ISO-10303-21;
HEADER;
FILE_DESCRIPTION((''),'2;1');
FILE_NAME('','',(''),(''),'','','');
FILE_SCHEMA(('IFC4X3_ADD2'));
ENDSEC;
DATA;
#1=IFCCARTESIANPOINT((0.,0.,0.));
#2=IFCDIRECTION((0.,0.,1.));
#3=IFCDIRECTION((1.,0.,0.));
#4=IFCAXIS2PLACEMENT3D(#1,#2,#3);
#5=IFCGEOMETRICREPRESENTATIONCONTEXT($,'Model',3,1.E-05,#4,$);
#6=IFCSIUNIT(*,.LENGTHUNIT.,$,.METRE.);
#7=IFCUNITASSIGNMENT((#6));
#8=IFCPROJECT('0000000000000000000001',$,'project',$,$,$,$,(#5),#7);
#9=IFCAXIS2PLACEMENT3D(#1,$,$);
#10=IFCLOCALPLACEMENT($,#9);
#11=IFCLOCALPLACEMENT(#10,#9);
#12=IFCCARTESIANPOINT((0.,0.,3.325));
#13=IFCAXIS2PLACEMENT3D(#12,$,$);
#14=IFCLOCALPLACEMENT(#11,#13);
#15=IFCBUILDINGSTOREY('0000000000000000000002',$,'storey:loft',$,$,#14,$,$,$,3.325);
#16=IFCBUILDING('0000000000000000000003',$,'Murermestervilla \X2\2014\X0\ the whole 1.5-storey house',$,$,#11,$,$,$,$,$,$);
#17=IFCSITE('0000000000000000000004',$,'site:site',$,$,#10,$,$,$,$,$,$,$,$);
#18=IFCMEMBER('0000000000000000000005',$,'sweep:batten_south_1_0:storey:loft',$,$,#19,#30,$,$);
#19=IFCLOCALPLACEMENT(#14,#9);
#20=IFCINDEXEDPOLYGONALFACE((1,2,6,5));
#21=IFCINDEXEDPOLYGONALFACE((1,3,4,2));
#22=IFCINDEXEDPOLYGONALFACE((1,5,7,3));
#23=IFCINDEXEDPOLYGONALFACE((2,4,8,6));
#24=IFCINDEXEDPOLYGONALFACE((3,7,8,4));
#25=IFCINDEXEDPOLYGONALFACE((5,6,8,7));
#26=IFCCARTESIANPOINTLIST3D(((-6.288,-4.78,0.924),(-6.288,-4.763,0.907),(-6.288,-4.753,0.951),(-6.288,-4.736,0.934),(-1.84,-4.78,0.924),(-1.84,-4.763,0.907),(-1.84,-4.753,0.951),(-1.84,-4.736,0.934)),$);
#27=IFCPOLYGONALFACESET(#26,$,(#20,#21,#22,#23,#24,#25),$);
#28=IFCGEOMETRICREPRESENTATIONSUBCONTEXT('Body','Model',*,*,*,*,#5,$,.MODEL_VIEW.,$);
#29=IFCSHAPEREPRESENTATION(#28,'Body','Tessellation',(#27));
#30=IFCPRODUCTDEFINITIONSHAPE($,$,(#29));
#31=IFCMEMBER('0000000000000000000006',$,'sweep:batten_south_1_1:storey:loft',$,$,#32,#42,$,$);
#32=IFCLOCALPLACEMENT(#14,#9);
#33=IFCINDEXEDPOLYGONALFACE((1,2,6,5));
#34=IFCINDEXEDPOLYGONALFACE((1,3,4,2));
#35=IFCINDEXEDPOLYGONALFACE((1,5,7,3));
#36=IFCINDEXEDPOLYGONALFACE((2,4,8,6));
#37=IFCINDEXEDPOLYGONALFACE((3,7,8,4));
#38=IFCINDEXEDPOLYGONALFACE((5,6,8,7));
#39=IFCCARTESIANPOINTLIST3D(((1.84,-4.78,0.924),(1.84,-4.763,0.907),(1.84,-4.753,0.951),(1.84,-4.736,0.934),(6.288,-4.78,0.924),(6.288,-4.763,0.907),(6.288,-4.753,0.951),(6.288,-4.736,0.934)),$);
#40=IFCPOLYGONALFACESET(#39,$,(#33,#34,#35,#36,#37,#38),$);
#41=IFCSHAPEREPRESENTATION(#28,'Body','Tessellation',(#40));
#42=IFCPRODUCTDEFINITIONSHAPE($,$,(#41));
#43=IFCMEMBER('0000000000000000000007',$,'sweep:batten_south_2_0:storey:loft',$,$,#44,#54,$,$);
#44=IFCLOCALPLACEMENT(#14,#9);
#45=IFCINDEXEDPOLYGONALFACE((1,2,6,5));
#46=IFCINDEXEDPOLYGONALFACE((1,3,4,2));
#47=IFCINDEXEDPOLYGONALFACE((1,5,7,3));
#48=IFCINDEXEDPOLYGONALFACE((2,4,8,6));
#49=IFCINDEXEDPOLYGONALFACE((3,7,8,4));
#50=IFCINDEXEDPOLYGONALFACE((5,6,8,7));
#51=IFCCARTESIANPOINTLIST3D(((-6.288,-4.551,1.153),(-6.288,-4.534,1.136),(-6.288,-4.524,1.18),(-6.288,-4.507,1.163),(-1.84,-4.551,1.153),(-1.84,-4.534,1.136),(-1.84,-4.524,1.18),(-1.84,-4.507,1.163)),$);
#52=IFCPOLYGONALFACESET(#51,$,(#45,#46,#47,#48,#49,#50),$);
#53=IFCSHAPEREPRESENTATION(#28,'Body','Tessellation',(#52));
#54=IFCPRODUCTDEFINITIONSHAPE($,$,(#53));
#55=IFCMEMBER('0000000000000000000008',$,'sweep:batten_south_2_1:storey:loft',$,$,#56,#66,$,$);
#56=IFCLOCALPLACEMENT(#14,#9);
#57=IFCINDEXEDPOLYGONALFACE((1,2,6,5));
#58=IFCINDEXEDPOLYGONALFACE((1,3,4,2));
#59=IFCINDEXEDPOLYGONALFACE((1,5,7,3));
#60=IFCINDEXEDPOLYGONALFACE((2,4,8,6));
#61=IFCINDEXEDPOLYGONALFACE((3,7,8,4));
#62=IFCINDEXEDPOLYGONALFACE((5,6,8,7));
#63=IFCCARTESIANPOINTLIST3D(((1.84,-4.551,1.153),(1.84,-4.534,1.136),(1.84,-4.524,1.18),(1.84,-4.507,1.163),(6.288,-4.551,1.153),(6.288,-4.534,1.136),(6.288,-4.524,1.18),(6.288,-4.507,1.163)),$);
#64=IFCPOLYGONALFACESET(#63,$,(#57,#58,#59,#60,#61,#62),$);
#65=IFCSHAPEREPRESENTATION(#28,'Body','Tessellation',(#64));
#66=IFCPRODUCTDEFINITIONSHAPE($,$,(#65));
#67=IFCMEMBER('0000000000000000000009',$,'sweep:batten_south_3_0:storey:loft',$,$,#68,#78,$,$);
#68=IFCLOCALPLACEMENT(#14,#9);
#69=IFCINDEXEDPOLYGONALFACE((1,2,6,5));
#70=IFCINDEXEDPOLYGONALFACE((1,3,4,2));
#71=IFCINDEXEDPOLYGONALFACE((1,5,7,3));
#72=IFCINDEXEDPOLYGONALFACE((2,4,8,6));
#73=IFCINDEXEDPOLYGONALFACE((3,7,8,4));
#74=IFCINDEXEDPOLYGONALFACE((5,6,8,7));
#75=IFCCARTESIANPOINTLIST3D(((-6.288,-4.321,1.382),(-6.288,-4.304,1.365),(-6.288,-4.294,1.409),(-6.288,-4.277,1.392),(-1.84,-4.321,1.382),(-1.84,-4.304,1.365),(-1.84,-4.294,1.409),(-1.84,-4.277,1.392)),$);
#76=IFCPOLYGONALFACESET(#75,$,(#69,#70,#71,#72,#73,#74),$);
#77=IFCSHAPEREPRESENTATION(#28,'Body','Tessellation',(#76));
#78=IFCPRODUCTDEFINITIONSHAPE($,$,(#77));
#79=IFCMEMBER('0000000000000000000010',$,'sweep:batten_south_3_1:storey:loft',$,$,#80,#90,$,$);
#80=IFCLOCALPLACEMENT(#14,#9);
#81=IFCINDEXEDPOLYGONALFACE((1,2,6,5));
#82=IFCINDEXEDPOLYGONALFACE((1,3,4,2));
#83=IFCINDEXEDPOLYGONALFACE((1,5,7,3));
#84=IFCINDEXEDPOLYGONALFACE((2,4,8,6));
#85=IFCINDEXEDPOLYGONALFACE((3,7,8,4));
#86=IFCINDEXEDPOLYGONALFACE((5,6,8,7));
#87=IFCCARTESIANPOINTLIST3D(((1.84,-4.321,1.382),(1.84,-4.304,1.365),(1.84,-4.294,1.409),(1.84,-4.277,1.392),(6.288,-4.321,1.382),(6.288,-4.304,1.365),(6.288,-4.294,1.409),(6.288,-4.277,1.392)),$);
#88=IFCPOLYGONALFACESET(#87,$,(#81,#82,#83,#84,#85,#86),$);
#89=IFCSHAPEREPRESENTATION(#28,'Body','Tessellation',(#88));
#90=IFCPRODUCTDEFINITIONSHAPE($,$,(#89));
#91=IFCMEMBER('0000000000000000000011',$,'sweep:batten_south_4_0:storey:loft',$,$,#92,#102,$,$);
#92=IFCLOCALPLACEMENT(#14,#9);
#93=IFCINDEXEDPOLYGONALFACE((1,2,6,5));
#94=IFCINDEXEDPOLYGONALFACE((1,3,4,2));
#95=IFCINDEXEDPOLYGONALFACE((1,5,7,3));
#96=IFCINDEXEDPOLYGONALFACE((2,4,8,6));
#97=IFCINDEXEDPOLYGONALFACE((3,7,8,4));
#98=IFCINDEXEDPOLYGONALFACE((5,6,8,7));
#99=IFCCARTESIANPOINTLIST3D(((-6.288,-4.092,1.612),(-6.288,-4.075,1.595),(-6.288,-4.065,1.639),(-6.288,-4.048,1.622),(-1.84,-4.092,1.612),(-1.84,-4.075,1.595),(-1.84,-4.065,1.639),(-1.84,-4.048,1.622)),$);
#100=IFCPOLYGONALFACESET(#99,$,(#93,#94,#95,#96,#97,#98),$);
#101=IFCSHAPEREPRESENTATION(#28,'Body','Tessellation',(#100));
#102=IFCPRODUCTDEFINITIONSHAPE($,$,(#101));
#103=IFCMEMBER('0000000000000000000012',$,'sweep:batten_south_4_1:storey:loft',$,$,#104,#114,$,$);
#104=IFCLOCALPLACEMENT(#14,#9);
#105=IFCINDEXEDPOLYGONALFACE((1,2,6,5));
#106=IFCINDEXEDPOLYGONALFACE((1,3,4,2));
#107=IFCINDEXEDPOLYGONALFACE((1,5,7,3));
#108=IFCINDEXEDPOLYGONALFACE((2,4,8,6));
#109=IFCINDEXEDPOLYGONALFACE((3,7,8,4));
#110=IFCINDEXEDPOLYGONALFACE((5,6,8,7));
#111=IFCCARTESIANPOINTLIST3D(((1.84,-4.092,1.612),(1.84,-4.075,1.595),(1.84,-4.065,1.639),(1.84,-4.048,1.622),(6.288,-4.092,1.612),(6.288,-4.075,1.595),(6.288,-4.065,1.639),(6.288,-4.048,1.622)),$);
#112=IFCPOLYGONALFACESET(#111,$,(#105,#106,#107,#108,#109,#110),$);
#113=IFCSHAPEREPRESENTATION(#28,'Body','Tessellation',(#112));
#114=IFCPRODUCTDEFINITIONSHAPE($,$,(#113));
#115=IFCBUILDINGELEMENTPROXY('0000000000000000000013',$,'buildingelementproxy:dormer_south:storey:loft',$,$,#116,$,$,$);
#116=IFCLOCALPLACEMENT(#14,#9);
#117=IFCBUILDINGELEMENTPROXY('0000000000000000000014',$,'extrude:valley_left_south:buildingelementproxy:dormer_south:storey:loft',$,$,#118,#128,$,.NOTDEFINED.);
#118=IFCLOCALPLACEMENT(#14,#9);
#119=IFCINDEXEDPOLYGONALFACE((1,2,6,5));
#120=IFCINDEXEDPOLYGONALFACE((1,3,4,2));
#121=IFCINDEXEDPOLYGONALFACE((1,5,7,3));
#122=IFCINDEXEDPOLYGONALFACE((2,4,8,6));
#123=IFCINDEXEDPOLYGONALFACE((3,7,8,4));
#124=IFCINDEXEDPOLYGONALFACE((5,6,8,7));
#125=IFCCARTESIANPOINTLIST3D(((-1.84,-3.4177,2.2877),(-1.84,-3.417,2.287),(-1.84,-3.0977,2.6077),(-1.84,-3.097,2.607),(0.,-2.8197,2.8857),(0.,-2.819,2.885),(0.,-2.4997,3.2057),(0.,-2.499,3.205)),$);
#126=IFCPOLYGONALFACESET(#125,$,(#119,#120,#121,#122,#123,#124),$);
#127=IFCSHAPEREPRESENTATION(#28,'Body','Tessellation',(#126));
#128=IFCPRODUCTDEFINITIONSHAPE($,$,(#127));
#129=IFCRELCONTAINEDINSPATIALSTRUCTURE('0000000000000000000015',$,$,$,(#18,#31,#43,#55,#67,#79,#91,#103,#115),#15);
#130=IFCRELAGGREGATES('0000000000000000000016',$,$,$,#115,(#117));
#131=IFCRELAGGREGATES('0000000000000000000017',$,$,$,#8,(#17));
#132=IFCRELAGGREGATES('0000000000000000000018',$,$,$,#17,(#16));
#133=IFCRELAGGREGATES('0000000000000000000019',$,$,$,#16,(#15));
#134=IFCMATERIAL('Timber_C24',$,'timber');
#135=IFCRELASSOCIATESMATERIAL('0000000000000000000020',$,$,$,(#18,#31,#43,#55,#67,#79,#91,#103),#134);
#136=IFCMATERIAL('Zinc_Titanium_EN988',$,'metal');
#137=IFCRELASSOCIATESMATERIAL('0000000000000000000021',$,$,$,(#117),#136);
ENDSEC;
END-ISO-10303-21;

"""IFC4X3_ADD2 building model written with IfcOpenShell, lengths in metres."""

from ifc_helpers import new_model, si_unit, frame, origin, origin_with_axes, place, context, subcontext, project, spatial, polyline, outline, extrude, material, element, aggregate, save


model = new_model("IFC4X3_ADD2")

# Units and contexts
model_context = context("Model", 3, precision=1e-05, world=origin_with_axes())
body_context = subcontext(model_context, "Body", "Model", "MODEL_VIEW")
ifc_project = project(units=[si_unit("LENGTHUNIT", "METRE")], contexts=[model_context])

# Shared definitions
ifc_material_1 = material(Name="Timber_C24", Category="timber")

# Site, building, storey
site_placement = place(None, origin())
site = spatial("IfcSite", under=ifc_project, at=site_placement, Name="site:site")
building_placement = place(site_placement, origin())
building = spatial("IfcBuilding", under=site, at=building_placement, Name="Murermestervilla — the whole 1.5-storey house")
storey_placement = place(building_placement, frame((0.0, 0.0, 3.325)))
storey = spatial("IfcBuildingStorey", under=building, at=storey_placement, Name="storey:loft", Elevation=3.325)

# Members
placement_1 = place(storey_placement, frame((0.0, 0.0, -3.325)))
element("IfcMember", 1, at=placement_1, inside=storey, material=ifc_material_1, Name="sweep:batten_south_1_0:storey:loft", context=body_context, shape_type="SweptSolid", body=[
    extrude(outline(polyline([(-0.005, -0.022), (0.022, 0.005), (0.005, 0.022), (-0.022, -0.005), (-0.005, -0.022)])), frame((-6.288, -4.758, 4.254), z_axis=(1.0, 0.0, 0.0), x_axis=(0.0, 1.0, 0.0)), (0.0, 0.0, 1.0), 4.448),
])
element("IfcMember", 2, at=placement_1, inside=storey, material=ifc_material_1, Name="sweep:batten_south_1_1:storey:loft", context=body_context, shape_type="SweptSolid", body=[
    extrude(outline(polyline([(-0.005, -0.022), (0.022, 0.005), (0.005, 0.022), (-0.022, -0.005), (-0.005, -0.022)])), frame((1.84, -4.758, 4.254), z_axis=(1.0, 0.0, 0.0), x_axis=(0.0, 1.0, 0.0)), (0.0, 0.0, 1.0), 4.448),
])
element("IfcMember", 3, at=placement_1, inside=storey, material=ifc_material_1, Name="sweep:batten_south_2_0:storey:loft", context=body_context, shape_type="SweptSolid", body=[
    extrude(outline(polyline([(-0.005, -0.022), (0.022, 0.005), (0.005, 0.022), (-0.022, -0.005), (-0.005, -0.022)])), frame((-6.288, -4.529, 4.483), z_axis=(1.0, 0.0, 0.0), x_axis=(0.0, 1.0, 0.0)), (0.0, 0.0, 1.0), 4.448),
])
element("IfcMember", 4, at=placement_1, inside=storey, material=ifc_material_1, Name="sweep:batten_south_2_1:storey:loft", context=body_context, shape_type="SweptSolid", body=[
    extrude(outline(polyline([(-0.005, -0.022), (0.022, 0.005), (0.005, 0.022), (-0.022, -0.005), (-0.005, -0.022)])), frame((1.84, -4.529, 4.483), z_axis=(1.0, 0.0, 0.0), x_axis=(0.0, 1.0, 0.0)), (0.0, 0.0, 1.0), 4.448),
])
element("IfcMember", 5, at=placement_1, inside=storey, material=ifc_material_1, Name="sweep:batten_south_3_0:storey:loft", context=body_context, shape_type="SweptSolid", body=[
    extrude(outline(polyline([(-0.005, -0.022), (0.022, 0.005), (0.005, 0.022), (-0.022, -0.005), (-0.005, -0.022)])), frame((-6.288, -4.299, 4.712), z_axis=(1.0, 0.0, 0.0), x_axis=(0.0, 1.0, 0.0)), (0.0, 0.0, 1.0), 4.448),
])
element("IfcMember", 6, at=placement_1, inside=storey, material=ifc_material_1, Name="sweep:batten_south_3_1:storey:loft", context=body_context, shape_type="SweptSolid", body=[
    extrude(outline(polyline([(-0.005, -0.022), (0.022, 0.005), (0.005, 0.022), (-0.022, -0.005), (-0.005, -0.022)])), frame((1.84, -4.299, 4.712), z_axis=(1.0, 0.0, 0.0), x_axis=(0.0, 1.0, 0.0)), (0.0, 0.0, 1.0), 4.448),
])
element("IfcMember", 7, at=placement_1, inside=storey, material=ifc_material_1, Name="sweep:batten_south_4_0:storey:loft", context=body_context, shape_type="SweptSolid", body=[
    extrude(outline(polyline([(-0.005, -0.022), (0.022, 0.005), (0.005, 0.022), (-0.022, -0.005), (-0.005, -0.022)])), frame((-6.288, -4.07, 4.942), z_axis=(1.0, 0.0, 0.0), x_axis=(0.0, 1.0, 0.0)), (0.0, 0.0, 1.0), 4.448),
])
element("IfcMember", 8, at=placement_1, inside=storey, material=ifc_material_1, Name="sweep:batten_south_4_1:storey:loft", context=body_context, shape_type="SweptSolid", body=[
    extrude(outline(polyline([(-0.005, -0.022), (0.022, 0.005), (0.005, 0.022), (-0.022, -0.005), (-0.005, -0.022)])), frame((1.84, -4.07, 4.942), z_axis=(1.0, 0.0, 0.0), x_axis=(0.0, 1.0, 0.0)), (0.0, 0.0, 1.0), 4.448),
])

# Building element proxy
proxy_1 = element("IfcBuildingElementProxy", 9, at=placement_1, inside=storey, Name="buildingelementproxy:dormer_south:storey:loft")
ifc_material_2 = material(Name="Zinc_Titanium_EN988", Category="metal")

# Building element proxy
proxy_2_placement = place(None, frame((-0.92, -2.958, 6.071), z_axis=(0.0, -0.707107, 0.707107), x_axis=(1.0, 0.0, 0.0)))
proxy_2 = element("IfcBuildingElementProxy", 10, at=proxy_2_placement, material=ifc_material_2, Name="extrude:valley_left_south:buildingelementproxy:dormer_south:storey:loft", PredefinedType="NOTDEFINED", context=body_context, shape_type="SweptSolid", body=[
    extrude(outline(polyline([(-0.92, -0.1966), (-0.92, -0.6491), (0.92, 0.1966), (0.92, 0.6491), (-0.92, -0.1966)])), origin(), (0.0, 0.0, 1.0), 0.001),
])
aggregate(proxy_1, [proxy_2])

save(model, "model.ifc")
